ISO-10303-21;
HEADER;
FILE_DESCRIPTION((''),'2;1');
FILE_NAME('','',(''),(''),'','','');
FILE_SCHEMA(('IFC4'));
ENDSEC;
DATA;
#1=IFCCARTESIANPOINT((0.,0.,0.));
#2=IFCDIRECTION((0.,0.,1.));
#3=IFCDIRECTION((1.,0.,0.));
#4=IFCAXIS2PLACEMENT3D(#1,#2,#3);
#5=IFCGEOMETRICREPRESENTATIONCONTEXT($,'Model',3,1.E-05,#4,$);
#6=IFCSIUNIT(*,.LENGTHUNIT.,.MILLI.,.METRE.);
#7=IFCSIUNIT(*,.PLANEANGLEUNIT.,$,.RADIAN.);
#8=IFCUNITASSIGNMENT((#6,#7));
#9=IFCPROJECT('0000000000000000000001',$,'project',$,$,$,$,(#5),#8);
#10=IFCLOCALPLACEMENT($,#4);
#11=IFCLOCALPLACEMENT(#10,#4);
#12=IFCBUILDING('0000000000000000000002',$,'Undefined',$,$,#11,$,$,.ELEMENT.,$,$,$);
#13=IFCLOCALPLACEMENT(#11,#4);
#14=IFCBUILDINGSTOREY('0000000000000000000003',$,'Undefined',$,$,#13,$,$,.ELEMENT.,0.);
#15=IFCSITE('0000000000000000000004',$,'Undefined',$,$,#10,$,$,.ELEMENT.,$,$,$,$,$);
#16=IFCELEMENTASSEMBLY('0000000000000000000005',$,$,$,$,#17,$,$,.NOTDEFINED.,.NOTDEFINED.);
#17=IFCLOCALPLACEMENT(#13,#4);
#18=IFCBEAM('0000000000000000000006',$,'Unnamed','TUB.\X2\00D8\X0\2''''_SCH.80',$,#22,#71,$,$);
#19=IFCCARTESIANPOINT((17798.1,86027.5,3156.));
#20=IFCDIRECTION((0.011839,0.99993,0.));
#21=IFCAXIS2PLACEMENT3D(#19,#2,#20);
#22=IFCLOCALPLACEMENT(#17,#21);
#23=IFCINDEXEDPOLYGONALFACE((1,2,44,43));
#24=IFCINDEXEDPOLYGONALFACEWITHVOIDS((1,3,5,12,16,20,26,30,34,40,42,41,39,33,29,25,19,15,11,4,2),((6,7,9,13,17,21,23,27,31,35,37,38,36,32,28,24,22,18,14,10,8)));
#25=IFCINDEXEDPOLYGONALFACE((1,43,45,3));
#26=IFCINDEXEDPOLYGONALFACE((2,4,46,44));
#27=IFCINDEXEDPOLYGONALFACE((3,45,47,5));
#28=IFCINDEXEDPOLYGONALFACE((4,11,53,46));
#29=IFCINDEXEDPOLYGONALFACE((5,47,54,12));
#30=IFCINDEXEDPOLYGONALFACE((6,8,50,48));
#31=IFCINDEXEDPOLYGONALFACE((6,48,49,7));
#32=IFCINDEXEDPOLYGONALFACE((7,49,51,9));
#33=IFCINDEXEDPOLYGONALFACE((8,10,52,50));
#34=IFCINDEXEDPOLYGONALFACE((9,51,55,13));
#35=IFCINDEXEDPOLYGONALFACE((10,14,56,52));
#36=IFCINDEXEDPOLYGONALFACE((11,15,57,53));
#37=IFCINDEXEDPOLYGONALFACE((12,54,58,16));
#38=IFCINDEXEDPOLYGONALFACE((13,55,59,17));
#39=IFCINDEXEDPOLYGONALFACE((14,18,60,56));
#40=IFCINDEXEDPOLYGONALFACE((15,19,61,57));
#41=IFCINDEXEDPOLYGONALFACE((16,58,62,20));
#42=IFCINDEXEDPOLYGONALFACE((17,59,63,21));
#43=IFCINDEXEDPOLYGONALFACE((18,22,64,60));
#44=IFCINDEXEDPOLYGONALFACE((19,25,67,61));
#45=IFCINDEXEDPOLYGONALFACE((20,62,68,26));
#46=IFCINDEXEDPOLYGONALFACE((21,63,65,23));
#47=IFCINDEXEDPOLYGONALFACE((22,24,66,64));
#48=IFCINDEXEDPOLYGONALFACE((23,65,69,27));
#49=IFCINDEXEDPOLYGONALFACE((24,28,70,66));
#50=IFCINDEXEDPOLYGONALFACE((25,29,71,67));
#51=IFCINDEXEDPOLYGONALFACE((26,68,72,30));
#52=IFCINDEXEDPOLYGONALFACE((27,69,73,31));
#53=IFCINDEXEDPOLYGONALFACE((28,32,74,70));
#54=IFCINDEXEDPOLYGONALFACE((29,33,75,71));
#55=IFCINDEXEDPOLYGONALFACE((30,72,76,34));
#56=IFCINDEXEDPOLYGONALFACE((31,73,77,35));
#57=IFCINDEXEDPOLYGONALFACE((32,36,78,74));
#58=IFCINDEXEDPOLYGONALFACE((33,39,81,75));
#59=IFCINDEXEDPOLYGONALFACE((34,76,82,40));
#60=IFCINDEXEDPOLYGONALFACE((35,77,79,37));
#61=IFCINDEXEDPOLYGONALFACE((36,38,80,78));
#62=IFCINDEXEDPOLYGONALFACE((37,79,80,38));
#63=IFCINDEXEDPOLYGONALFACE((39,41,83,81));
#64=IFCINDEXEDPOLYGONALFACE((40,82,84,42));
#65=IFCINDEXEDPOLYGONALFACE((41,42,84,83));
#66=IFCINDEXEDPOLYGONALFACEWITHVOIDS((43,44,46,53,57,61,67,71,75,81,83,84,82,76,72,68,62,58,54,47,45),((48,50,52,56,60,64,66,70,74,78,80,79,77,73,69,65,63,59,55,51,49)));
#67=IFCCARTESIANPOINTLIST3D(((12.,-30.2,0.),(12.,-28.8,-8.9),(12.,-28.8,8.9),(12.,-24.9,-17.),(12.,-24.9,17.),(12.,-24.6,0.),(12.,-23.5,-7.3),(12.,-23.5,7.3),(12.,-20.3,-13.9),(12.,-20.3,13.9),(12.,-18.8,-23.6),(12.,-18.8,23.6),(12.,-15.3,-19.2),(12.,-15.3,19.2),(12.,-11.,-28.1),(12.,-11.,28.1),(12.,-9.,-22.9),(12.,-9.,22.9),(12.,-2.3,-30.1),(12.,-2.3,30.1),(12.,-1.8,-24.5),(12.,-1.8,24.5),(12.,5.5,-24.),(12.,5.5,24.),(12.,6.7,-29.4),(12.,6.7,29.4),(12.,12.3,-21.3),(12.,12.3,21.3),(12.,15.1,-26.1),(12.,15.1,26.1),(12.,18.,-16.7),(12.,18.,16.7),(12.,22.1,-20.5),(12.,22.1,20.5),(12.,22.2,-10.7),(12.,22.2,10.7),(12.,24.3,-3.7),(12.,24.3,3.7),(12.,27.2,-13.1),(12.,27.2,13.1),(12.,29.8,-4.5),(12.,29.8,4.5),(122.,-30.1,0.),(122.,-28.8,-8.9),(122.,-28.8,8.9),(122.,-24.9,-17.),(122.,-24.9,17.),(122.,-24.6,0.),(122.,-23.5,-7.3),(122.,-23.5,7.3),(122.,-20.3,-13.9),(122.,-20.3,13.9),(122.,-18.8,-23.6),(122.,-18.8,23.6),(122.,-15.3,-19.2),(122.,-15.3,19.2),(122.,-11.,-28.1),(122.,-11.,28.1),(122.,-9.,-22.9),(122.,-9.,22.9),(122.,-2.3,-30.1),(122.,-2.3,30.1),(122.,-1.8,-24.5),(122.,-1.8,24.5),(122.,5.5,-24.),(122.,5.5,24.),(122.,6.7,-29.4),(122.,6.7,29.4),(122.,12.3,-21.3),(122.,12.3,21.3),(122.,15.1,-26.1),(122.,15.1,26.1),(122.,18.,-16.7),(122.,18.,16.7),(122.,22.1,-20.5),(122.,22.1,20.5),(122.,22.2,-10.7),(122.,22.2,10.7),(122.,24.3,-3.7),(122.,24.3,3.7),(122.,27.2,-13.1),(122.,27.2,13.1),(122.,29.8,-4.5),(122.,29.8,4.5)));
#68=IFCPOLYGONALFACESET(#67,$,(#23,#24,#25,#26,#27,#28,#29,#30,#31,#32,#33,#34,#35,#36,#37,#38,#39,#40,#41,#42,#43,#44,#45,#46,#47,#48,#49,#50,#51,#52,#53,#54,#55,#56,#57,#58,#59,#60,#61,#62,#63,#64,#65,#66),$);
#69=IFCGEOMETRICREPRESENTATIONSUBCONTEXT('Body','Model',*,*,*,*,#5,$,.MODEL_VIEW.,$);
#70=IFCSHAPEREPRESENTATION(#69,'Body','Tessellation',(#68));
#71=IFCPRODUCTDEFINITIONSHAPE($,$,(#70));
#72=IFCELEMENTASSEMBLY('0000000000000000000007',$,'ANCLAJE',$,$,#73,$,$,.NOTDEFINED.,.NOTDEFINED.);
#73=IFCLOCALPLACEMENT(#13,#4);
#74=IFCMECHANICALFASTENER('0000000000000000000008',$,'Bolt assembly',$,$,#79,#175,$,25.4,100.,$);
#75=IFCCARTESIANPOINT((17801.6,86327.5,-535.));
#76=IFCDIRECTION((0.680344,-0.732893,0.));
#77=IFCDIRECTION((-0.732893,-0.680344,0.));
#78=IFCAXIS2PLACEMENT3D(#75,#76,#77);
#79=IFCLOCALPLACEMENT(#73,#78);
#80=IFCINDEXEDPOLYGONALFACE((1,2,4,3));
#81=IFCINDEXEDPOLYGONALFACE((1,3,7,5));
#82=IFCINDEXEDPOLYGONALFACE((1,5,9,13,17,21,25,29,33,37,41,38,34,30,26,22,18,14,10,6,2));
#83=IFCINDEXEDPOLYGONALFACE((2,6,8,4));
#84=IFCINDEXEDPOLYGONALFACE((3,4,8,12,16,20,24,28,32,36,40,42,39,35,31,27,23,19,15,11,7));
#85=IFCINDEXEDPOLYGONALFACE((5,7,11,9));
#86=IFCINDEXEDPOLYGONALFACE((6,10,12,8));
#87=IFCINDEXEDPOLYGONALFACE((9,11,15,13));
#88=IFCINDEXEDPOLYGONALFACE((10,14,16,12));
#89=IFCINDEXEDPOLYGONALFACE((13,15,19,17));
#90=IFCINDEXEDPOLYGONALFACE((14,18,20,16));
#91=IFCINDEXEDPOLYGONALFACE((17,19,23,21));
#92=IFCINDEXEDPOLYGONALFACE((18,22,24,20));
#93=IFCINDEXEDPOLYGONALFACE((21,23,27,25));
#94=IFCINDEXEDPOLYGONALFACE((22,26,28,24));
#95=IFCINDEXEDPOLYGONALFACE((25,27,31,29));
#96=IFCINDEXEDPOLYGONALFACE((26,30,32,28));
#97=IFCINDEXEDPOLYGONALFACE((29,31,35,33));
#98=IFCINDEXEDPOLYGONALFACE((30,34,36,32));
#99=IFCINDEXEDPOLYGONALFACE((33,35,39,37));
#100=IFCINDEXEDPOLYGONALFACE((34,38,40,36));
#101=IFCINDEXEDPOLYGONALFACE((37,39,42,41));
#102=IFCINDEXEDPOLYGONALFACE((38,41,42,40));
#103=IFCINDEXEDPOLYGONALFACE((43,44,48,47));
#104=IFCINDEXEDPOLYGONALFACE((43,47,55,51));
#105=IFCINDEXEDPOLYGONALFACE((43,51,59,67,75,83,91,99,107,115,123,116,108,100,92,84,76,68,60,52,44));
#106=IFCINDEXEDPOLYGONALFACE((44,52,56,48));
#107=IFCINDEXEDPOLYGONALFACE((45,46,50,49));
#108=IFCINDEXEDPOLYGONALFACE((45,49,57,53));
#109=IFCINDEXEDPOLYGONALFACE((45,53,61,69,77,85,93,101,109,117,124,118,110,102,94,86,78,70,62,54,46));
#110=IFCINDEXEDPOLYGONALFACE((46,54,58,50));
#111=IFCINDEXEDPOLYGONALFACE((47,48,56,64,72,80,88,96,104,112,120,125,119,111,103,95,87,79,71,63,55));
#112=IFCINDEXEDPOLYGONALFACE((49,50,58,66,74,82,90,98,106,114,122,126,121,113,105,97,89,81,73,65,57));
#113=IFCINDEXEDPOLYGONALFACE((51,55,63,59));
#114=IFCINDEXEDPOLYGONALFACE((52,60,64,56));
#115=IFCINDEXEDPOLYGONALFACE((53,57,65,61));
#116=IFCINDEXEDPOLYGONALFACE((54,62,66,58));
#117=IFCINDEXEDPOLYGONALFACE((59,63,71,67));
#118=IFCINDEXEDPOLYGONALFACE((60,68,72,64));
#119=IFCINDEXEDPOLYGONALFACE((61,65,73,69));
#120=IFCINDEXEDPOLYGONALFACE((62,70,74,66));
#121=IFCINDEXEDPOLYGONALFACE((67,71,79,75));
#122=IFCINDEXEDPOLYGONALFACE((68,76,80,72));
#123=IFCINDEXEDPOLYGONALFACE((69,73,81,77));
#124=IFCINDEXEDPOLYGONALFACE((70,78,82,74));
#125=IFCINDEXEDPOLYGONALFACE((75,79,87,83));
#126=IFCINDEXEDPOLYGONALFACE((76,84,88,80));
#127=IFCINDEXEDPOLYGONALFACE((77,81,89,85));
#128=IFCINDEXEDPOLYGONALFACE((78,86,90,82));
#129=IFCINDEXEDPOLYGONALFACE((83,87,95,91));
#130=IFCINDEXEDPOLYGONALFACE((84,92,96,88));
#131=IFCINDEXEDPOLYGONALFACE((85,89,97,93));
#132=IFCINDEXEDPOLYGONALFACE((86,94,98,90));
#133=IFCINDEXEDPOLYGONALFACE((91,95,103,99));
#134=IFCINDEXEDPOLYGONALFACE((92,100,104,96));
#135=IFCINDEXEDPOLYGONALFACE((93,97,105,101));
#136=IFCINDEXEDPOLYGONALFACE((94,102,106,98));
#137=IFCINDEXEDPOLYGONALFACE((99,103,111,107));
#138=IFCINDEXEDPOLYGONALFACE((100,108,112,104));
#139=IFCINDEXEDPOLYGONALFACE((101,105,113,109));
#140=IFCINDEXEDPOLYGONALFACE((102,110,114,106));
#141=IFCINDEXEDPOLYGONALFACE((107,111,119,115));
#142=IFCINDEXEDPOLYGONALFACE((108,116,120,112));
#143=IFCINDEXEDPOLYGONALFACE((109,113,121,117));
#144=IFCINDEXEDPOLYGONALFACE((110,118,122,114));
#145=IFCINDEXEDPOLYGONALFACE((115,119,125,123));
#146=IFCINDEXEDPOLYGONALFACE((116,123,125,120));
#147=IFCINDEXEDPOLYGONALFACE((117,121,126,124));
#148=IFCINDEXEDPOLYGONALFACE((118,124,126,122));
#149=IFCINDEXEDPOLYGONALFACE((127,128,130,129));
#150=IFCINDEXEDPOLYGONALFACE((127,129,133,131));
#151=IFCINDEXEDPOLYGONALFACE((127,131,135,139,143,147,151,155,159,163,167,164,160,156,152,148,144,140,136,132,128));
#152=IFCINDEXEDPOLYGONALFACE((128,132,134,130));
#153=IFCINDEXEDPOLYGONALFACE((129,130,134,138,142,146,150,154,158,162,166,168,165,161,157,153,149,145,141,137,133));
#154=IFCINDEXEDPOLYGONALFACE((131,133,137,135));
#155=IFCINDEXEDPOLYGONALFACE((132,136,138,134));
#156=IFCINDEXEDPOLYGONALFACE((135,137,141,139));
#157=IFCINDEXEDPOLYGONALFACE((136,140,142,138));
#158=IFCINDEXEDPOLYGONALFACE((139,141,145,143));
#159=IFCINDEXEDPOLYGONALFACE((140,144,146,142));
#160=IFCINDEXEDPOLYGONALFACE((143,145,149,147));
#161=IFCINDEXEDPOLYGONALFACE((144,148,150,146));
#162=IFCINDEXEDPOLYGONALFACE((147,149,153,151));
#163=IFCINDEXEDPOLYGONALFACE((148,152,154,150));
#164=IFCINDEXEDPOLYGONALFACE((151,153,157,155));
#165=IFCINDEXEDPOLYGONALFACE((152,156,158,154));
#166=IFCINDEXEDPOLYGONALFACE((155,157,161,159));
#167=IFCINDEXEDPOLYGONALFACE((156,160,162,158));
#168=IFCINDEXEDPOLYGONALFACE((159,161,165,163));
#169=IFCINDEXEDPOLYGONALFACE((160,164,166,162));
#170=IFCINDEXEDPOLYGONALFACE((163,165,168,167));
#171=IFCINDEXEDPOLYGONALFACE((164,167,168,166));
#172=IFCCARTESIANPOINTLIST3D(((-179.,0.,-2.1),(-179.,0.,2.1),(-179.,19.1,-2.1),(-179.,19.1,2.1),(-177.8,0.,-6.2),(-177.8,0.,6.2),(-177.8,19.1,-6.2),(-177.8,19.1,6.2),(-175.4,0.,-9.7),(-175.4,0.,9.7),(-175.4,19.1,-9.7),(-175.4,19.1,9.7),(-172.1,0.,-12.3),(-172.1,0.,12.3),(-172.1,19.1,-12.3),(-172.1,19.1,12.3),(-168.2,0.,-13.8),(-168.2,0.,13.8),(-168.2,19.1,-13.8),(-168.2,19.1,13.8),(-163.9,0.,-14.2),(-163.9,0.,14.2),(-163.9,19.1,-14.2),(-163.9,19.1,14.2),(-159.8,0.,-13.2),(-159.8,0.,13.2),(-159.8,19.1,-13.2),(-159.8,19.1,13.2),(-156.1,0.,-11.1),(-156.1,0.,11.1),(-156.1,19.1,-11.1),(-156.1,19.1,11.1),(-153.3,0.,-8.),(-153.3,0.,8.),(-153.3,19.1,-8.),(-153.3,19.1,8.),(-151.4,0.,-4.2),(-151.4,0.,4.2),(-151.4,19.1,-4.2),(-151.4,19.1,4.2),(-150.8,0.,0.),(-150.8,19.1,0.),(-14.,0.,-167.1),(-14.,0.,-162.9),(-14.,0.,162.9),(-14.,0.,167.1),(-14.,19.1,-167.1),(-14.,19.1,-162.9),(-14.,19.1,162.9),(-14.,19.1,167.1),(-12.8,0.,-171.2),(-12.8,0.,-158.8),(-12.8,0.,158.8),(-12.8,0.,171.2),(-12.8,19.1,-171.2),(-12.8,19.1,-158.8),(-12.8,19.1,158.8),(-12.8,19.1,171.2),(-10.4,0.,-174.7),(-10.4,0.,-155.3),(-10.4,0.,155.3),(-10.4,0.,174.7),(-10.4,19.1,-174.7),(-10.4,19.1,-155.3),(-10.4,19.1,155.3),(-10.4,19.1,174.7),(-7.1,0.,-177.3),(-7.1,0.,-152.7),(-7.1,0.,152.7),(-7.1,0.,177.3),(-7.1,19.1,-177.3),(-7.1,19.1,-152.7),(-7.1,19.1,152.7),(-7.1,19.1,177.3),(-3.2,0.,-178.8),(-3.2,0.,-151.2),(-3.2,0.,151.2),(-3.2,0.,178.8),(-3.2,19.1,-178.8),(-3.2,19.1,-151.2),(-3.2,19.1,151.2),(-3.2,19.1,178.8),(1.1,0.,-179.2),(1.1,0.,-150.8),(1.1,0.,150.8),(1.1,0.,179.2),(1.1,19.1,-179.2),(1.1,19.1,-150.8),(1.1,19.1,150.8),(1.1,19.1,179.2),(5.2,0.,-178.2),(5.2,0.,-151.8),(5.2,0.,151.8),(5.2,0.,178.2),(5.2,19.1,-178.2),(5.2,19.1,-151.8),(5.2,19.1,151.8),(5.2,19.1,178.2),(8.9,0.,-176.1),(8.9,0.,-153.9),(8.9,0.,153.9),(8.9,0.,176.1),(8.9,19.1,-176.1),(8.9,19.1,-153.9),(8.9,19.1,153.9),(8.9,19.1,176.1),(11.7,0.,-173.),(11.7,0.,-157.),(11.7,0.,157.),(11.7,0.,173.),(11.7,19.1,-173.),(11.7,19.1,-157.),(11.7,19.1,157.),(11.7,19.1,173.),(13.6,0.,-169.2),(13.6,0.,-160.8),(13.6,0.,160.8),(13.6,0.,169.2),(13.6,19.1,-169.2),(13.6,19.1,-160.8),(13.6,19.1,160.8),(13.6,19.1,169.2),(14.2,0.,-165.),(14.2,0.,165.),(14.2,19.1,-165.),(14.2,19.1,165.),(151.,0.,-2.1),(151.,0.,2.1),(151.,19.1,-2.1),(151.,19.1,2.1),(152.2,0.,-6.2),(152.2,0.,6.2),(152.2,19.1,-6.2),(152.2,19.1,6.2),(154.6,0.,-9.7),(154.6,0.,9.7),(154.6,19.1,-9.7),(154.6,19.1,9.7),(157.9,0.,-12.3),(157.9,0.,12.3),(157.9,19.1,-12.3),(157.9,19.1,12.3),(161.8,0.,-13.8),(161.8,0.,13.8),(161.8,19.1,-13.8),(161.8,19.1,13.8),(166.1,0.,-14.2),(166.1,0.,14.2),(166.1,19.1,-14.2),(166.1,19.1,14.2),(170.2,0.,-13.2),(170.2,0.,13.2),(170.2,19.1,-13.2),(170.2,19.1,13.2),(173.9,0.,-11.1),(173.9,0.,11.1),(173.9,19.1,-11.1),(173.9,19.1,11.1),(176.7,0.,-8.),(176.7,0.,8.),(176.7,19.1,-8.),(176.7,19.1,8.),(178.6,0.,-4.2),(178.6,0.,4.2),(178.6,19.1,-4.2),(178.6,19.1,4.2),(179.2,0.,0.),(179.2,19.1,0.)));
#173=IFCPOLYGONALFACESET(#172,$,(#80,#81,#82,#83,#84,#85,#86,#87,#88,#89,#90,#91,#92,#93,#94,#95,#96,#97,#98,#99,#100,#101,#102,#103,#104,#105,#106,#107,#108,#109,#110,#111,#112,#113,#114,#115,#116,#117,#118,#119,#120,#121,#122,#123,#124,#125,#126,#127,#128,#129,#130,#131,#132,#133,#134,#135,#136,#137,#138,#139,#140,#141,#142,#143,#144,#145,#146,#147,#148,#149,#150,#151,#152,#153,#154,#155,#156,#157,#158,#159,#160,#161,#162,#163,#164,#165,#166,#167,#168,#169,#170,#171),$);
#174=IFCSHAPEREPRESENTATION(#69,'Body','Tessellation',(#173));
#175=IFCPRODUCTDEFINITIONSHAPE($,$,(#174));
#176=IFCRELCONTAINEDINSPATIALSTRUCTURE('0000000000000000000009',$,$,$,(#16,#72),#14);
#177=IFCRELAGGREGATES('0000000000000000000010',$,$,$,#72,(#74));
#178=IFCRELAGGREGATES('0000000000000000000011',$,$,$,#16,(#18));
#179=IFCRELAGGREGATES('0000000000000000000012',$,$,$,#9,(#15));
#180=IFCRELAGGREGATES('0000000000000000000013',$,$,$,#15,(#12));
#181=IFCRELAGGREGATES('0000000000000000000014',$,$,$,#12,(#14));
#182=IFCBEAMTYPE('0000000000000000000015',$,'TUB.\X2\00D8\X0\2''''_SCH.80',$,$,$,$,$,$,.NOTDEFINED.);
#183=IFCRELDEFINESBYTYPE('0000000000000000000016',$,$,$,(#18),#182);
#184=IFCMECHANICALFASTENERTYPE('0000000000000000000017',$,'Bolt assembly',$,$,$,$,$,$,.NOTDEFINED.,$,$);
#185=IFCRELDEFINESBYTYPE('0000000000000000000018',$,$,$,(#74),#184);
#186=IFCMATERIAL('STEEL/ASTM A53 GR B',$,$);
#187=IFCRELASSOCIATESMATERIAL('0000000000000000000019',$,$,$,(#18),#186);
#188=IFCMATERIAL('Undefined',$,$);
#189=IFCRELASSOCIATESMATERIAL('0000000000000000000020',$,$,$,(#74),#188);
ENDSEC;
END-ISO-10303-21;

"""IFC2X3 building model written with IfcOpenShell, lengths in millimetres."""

from ifc_helpers import new_model, si_unit, frame, origin_with_axes, origin_2d_with_axis, place, context, subcontext, project, spatial, circle, hollow_circle, extrude, clip, halfspace, source, transform, mapped, material, type_object, element, aggregate, save


model = new_model("IFC2X3")

# Units and contexts
model_context = context("Model", 3, precision=1e-05, world=origin_with_axes())
body_context = subcontext(model_context, "Body", "Model", "MODEL_VIEW")
ifc_project = project(units=[si_unit("LENGTHUNIT", "METRE", prefix="MILLI"), si_unit("PLANEANGLEUNIT", "RADIAN")], contexts=[model_context])

# Site, building, storey
site_placement = place(None, origin_with_axes())
site = spatial("IfcSite", under=ifc_project, at=site_placement, Name="Undefined", CompositionType="ELEMENT")
building_placement = place(site_placement, origin_with_axes())
building = spatial("IfcBuilding", under=site, at=building_placement, Name="Undefined", CompositionType="ELEMENT")
storey_placement = place(building_placement, origin_with_axes())
storey = spatial("IfcBuildingStorey", under=building, at=storey_placement, Name="Undefined", CompositionType="ELEMENT", Elevation=0.0)

# Element assembly, beam
assembly_1_placement = place(storey_placement, origin_with_axes())
assembly_1 = element("IfcElementAssembly", 1, at=assembly_1_placement, inside=storey, AssemblyPlace="NOTDEFINED", PredefinedType="NOTDEFINED")
ifc_material_1 = material(Name="STEEL/ASTM A53 GR B")
beam_type_1 = type_object("IfcBeamType", Name="TUB.Ø2''_SCH.80", PredefinedType="NOTDEFINED")
beam_1_placement = place(assembly_1_placement, frame((17798.1, 86027.5, 3156.0), z_axis=(0.0, 0.0, 1.0), x_axis=(0.011839, 0.99993, 0.0)))
beam_1 = element("IfcBeam", 2, at=beam_1_placement, type_object=beam_type_1, material=ifc_material_1, Name="Unnamed", Description="TUB.Ø2''_SCH.80", context=body_context, shape_type="Clipping", body=[
    clip(extrude(hollow_circle(Radius=30.1, WallThickness=5.5, at=origin_2d_with_axis()), frame((122.0, 0.0, 0.0), z_axis=(-1.0, 0.0, 0.0), x_axis=(0.0, -1.0, 0.0)), (0.0, 0.0, 1.0), 122.0), halfspace(frame((12.0, 0.0, 0.0), z_axis=(1.0, 0.0, 0.0), x_axis=(0.0, -1.0, 0.0)), True)),
])

# Element assembly, mechanical fastener
assembly_2_placement = place(storey_placement, origin_with_axes())
assembly_2 = element("IfcElementAssembly", 3, at=assembly_2_placement, inside=storey, Name="ANCLAJE", AssemblyPlace="NOTDEFINED", PredefinedType="NOTDEFINED")
ifc_material_2 = material(Name="Undefined")
mechanical_fastener_type = type_object("IfcMechanicalFastenerType", Name="Bolt assembly")
shared_shape_1 = source(origin_with_axes(), body_context, "Body", "SweptSolid", [
    extrude(circle(Radius=14.2, at=origin_2d_with_axis()), frame((0.0, 0.0, 0.0), z_axis=(0.0, 1.0, 0.0), x_axis=(1.0, 0.0, 0.0)), (0.0, 0.0, 1.0), 19.1),
])
mechanical_fastener_1_placement = place(assembly_2_placement, frame((17801.6, 86327.5, -535.0), z_axis=(0.680344, -0.732893, 0.0), x_axis=(-0.732893, -0.680344, 0.0)))
mechanical_fastener_1 = element("IfcMechanicalFastener", 4, at=mechanical_fastener_1_placement, type_object=mechanical_fastener_type, material=ifc_material_2, Name="Bolt assembly", NominalDiameter=25.4, NominalLength=100.0, context=body_context, shape_type="MappedRepresentation", body=[
    mapped(shared_shape_1, transform((165.0, 0.0, 0.0))),
    mapped(shared_shape_1, transform((0.0, 0.0, 165.0))),
    mapped(shared_shape_1, transform((-165.0, 0.0, 0.0))),
    mapped(shared_shape_1, transform((0.0, 0.0, -165.0))),
])
aggregate(assembly_2, [mechanical_fastener_1])

aggregate(assembly_1, [beam_1])

save(model, "model.ifc")
